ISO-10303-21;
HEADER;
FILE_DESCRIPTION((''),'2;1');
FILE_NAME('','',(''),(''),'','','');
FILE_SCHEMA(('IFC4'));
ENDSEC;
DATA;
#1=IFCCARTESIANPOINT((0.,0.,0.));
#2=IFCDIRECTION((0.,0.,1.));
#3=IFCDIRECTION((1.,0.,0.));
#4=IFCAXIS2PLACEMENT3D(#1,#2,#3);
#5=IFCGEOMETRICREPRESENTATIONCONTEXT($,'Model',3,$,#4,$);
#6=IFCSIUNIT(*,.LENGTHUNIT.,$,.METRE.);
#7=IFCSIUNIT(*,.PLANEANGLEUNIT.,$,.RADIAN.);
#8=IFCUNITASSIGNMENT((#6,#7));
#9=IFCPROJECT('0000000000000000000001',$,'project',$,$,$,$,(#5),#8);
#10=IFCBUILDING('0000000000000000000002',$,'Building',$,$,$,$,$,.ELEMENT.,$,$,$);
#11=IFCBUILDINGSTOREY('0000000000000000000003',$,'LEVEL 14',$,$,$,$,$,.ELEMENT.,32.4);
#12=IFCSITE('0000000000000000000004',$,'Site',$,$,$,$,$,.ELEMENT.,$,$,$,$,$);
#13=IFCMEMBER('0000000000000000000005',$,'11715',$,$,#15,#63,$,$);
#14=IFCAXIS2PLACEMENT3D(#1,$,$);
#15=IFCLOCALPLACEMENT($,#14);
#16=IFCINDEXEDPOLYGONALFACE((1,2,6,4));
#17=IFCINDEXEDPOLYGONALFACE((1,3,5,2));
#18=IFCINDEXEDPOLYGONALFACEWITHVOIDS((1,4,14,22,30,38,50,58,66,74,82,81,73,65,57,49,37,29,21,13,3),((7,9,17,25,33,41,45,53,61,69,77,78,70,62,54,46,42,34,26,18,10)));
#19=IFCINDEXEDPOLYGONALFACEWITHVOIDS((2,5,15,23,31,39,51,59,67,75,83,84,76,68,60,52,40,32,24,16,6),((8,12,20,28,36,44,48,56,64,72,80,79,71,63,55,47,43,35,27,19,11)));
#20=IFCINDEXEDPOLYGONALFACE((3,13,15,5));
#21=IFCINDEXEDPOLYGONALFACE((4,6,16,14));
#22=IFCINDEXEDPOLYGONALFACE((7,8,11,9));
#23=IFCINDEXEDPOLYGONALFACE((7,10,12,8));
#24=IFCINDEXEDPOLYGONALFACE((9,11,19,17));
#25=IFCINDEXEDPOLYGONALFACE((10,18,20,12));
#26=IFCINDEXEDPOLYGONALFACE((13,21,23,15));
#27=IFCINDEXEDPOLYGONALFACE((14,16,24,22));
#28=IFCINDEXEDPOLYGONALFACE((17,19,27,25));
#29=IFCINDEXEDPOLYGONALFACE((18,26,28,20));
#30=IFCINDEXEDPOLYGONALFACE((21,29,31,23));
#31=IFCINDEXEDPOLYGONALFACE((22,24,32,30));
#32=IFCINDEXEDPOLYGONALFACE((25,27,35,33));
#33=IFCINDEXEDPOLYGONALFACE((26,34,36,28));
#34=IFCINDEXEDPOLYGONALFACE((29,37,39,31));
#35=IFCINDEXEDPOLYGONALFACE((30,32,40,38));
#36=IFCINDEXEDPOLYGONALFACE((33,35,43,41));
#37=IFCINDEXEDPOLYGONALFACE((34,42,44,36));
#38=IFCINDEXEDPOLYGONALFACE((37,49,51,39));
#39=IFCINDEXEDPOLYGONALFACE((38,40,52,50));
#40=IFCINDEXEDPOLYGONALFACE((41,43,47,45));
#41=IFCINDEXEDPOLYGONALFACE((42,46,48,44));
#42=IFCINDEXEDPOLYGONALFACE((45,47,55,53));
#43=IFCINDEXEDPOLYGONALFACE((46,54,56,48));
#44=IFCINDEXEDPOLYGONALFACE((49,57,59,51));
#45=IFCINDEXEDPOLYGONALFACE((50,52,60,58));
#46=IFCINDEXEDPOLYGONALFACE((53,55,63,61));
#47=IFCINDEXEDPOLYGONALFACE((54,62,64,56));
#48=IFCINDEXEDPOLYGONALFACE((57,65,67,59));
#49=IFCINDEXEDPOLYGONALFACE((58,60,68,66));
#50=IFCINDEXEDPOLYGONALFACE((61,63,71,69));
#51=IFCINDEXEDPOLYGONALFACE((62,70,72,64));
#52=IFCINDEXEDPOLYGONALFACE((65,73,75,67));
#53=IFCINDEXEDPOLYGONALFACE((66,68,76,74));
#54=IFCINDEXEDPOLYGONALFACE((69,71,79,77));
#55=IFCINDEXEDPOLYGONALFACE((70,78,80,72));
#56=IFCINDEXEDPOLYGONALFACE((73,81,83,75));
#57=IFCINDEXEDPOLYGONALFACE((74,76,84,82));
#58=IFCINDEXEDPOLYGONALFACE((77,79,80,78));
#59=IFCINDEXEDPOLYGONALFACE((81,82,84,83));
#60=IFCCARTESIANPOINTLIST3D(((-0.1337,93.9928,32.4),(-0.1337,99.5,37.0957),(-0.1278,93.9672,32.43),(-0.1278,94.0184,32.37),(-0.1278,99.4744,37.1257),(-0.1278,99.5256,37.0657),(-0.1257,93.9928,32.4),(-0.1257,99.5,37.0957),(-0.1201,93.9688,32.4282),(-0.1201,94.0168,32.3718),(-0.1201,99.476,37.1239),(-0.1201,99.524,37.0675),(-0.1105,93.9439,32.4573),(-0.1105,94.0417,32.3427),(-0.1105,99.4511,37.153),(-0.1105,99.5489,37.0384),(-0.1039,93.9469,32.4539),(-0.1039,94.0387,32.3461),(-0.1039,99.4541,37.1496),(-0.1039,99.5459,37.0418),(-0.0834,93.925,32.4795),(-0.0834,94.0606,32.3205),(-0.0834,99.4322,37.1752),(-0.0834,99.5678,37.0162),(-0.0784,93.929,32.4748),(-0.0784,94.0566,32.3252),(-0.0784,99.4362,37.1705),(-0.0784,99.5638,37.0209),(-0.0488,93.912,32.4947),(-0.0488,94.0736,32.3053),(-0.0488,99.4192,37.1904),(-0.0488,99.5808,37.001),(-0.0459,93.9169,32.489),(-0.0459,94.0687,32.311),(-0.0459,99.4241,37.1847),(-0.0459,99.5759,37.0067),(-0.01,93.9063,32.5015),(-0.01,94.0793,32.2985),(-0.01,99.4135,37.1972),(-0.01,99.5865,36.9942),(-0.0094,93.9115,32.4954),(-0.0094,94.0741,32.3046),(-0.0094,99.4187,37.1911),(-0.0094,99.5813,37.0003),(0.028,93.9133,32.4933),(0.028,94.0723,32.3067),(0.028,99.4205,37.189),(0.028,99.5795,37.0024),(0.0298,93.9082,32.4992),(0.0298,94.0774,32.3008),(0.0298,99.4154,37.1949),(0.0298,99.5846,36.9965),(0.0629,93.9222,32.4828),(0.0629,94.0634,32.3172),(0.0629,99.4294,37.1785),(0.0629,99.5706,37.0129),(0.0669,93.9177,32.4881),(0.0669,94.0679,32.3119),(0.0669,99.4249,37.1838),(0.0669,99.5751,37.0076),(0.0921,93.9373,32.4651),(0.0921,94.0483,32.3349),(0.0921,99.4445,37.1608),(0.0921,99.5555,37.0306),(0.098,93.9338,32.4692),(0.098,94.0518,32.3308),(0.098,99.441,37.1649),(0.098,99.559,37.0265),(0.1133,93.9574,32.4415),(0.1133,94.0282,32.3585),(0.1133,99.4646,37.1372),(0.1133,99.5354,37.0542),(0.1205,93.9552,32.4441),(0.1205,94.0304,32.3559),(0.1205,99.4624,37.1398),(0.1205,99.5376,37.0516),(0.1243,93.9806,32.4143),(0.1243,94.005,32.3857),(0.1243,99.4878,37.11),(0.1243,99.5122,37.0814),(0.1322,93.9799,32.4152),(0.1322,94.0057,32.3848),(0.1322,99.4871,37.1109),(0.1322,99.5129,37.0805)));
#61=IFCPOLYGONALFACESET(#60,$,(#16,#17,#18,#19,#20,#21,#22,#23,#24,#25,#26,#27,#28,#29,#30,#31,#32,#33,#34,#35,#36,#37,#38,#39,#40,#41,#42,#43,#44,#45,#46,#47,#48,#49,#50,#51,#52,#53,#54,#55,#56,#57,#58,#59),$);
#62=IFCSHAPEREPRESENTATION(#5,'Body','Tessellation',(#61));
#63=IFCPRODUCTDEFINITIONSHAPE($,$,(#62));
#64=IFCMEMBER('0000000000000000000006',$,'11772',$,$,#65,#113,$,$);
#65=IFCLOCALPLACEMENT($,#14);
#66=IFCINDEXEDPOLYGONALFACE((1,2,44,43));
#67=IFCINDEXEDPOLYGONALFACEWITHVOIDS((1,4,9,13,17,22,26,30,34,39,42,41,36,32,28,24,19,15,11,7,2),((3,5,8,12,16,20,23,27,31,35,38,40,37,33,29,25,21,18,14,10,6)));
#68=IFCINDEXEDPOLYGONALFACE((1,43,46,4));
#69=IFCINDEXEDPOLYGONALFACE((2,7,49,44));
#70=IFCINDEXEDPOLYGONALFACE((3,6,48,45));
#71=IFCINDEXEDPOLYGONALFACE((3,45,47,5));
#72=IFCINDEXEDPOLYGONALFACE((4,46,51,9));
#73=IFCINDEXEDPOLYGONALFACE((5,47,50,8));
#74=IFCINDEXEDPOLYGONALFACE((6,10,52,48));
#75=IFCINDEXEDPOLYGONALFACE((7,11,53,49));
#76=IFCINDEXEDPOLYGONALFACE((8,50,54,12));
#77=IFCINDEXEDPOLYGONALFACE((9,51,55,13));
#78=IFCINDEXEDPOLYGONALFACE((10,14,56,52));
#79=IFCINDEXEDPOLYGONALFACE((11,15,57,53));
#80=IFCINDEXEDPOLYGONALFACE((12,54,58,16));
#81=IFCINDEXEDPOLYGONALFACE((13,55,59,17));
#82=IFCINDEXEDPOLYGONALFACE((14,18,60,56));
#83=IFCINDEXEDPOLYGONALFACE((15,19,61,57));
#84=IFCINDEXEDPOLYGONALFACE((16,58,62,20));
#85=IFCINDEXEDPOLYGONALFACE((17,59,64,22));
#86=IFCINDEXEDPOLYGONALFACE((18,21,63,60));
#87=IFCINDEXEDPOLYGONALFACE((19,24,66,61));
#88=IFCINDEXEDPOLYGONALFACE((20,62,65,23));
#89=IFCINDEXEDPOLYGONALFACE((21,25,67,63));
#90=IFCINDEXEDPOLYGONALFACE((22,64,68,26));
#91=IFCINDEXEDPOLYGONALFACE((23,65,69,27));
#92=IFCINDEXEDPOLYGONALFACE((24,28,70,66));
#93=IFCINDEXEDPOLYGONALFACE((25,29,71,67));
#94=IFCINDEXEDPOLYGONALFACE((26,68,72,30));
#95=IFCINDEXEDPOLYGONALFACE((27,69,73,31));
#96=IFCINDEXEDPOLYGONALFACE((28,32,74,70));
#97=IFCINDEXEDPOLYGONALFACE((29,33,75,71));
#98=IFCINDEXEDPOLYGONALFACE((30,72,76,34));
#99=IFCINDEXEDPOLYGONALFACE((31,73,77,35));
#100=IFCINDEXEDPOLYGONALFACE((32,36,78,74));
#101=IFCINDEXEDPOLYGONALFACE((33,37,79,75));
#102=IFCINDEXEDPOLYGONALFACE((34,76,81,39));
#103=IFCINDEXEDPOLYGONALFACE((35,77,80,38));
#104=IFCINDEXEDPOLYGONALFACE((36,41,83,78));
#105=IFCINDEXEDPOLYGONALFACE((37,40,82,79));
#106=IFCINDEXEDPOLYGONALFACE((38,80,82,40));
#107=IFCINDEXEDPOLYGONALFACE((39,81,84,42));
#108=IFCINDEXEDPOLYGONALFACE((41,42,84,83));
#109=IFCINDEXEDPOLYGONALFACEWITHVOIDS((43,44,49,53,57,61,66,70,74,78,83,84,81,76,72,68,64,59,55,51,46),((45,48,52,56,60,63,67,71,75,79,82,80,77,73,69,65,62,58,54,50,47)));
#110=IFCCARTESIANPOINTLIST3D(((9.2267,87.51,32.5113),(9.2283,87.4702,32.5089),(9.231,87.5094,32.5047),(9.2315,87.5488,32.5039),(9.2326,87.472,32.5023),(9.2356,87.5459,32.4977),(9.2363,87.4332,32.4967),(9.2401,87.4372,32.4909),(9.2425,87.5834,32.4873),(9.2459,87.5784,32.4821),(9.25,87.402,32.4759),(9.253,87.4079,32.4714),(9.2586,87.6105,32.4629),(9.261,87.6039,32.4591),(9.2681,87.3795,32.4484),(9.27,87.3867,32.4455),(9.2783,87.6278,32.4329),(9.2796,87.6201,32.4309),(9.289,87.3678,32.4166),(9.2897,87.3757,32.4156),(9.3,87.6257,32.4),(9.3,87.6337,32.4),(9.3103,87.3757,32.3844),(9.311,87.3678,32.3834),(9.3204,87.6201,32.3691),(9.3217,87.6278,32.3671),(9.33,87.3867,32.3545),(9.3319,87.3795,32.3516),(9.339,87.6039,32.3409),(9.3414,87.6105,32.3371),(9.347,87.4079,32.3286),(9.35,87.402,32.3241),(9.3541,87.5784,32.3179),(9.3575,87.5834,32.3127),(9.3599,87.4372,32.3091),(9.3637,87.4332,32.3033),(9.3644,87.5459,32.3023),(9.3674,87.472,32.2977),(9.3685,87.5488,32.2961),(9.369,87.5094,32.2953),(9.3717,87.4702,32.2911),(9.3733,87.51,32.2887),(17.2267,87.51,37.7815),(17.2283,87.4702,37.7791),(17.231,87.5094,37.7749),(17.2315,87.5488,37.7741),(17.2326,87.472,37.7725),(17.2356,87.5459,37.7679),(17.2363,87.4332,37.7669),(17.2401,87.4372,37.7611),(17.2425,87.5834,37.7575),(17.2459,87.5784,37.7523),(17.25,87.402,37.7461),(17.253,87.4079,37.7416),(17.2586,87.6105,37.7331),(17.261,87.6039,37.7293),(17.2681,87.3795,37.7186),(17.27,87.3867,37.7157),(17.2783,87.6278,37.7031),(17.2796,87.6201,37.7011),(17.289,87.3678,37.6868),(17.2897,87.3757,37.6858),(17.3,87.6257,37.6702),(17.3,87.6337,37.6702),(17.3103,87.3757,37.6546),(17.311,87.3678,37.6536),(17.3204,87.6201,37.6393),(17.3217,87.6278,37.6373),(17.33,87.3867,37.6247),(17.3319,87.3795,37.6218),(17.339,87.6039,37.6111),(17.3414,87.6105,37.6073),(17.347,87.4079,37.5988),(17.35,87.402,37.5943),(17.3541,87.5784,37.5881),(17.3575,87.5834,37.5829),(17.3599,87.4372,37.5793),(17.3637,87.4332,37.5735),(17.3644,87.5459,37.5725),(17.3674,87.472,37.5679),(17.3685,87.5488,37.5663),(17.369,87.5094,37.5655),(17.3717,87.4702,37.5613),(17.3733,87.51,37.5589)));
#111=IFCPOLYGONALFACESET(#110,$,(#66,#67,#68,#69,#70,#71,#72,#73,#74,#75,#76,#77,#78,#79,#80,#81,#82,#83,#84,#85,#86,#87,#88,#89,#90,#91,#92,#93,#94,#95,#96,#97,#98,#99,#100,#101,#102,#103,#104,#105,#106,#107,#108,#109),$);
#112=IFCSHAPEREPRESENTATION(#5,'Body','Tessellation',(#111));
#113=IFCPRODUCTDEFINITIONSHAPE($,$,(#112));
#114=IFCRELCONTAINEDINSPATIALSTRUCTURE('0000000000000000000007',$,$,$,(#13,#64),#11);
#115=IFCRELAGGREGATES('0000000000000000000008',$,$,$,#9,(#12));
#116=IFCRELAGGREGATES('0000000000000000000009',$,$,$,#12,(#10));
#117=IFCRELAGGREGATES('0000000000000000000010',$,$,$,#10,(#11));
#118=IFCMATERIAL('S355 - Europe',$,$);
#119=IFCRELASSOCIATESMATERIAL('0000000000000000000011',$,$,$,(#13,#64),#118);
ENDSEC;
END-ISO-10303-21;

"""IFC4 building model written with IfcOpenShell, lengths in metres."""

from ifc_helpers import new_model, si_unit, frame, origin_with_axes, origin_2d_with_axis, place, context, project, spatial, hollow_circle, extrude, material, material_profile, profile_set, profile_usage, element, save


model = new_model("IFC4")

# Units and contexts
model_context = context("Model", 3, world=origin_with_axes())
ifc_project = project(units=[si_unit("LENGTHUNIT", "METRE"), si_unit("PLANEANGLEUNIT", "RADIAN")], contexts=[model_context])

# Site, building, storey
site = spatial("IfcSite", under=ifc_project, Name="Site", CompositionType="ELEMENT")
building = spatial("IfcBuilding", under=site, Name="Building", CompositionType="ELEMENT")
storey = spatial("IfcBuildingStorey", under=building, Name="LEVEL 14", CompositionType="ELEMENT", Elevation=32.4)

# Shared definitions
ifc_material = material(Name="S355 - Europe")

# Members
ifc_material_profile_1 = material_profile(ifc_material, hollow_circle(Radius=0.1337, WallThickness=0.008, at=origin_2d_with_axis()))
ifc_profile_set_1 = profile_set([ifc_material_profile_1])
ifc_profile_usage_1 = profile_usage(ifc_profile_set_1, cardinal=10)
member_1_placement = place(None, frame((0.0, 93.9928, 32.4), z_axis=(0.0, 0.760944, 0.648817), x_axis=(-1.0, 0.0, 0.0)))
element("IfcMember", 1, at=member_1_placement, inside=storey, material=ifc_profile_usage_1, Name="11715", context=model_context, shape_type="SweptSolid", body=[
    extrude(hollow_circle(Radius=0.1337, WallThickness=0.008, at=origin_2d_with_axis()), origin_with_axes(), (0.0, 0.0, 1.0), 7.2373),
])
ifc_material_profile_2 = material_profile(ifc_material, hollow_circle(Radius=0.1337, WallThickness=0.008, at=origin_2d_with_axis()))
ifc_profile_set_2 = profile_set([ifc_material_profile_2])
ifc_profile_usage_2 = profile_usage(ifc_profile_set_2, cardinal=10)
member_2_placement = place(None, frame((9.3, 87.5, 32.4), z_axis=(0.835079, 0.0, 0.550129), x_axis=(0.0, 1.0, 0.0)))
element("IfcMember", 2, at=member_2_placement, inside=storey, material=ifc_profile_usage_2, Name="11772", context=model_context, shape_type="SweptSolid", body=[
    extrude(hollow_circle(Radius=0.1337, WallThickness=0.008, at=origin_2d_with_axis()), origin_with_axes(), (0.0, 0.0, 1.0), 9.5799),
])

save(model, "model.ifc")
